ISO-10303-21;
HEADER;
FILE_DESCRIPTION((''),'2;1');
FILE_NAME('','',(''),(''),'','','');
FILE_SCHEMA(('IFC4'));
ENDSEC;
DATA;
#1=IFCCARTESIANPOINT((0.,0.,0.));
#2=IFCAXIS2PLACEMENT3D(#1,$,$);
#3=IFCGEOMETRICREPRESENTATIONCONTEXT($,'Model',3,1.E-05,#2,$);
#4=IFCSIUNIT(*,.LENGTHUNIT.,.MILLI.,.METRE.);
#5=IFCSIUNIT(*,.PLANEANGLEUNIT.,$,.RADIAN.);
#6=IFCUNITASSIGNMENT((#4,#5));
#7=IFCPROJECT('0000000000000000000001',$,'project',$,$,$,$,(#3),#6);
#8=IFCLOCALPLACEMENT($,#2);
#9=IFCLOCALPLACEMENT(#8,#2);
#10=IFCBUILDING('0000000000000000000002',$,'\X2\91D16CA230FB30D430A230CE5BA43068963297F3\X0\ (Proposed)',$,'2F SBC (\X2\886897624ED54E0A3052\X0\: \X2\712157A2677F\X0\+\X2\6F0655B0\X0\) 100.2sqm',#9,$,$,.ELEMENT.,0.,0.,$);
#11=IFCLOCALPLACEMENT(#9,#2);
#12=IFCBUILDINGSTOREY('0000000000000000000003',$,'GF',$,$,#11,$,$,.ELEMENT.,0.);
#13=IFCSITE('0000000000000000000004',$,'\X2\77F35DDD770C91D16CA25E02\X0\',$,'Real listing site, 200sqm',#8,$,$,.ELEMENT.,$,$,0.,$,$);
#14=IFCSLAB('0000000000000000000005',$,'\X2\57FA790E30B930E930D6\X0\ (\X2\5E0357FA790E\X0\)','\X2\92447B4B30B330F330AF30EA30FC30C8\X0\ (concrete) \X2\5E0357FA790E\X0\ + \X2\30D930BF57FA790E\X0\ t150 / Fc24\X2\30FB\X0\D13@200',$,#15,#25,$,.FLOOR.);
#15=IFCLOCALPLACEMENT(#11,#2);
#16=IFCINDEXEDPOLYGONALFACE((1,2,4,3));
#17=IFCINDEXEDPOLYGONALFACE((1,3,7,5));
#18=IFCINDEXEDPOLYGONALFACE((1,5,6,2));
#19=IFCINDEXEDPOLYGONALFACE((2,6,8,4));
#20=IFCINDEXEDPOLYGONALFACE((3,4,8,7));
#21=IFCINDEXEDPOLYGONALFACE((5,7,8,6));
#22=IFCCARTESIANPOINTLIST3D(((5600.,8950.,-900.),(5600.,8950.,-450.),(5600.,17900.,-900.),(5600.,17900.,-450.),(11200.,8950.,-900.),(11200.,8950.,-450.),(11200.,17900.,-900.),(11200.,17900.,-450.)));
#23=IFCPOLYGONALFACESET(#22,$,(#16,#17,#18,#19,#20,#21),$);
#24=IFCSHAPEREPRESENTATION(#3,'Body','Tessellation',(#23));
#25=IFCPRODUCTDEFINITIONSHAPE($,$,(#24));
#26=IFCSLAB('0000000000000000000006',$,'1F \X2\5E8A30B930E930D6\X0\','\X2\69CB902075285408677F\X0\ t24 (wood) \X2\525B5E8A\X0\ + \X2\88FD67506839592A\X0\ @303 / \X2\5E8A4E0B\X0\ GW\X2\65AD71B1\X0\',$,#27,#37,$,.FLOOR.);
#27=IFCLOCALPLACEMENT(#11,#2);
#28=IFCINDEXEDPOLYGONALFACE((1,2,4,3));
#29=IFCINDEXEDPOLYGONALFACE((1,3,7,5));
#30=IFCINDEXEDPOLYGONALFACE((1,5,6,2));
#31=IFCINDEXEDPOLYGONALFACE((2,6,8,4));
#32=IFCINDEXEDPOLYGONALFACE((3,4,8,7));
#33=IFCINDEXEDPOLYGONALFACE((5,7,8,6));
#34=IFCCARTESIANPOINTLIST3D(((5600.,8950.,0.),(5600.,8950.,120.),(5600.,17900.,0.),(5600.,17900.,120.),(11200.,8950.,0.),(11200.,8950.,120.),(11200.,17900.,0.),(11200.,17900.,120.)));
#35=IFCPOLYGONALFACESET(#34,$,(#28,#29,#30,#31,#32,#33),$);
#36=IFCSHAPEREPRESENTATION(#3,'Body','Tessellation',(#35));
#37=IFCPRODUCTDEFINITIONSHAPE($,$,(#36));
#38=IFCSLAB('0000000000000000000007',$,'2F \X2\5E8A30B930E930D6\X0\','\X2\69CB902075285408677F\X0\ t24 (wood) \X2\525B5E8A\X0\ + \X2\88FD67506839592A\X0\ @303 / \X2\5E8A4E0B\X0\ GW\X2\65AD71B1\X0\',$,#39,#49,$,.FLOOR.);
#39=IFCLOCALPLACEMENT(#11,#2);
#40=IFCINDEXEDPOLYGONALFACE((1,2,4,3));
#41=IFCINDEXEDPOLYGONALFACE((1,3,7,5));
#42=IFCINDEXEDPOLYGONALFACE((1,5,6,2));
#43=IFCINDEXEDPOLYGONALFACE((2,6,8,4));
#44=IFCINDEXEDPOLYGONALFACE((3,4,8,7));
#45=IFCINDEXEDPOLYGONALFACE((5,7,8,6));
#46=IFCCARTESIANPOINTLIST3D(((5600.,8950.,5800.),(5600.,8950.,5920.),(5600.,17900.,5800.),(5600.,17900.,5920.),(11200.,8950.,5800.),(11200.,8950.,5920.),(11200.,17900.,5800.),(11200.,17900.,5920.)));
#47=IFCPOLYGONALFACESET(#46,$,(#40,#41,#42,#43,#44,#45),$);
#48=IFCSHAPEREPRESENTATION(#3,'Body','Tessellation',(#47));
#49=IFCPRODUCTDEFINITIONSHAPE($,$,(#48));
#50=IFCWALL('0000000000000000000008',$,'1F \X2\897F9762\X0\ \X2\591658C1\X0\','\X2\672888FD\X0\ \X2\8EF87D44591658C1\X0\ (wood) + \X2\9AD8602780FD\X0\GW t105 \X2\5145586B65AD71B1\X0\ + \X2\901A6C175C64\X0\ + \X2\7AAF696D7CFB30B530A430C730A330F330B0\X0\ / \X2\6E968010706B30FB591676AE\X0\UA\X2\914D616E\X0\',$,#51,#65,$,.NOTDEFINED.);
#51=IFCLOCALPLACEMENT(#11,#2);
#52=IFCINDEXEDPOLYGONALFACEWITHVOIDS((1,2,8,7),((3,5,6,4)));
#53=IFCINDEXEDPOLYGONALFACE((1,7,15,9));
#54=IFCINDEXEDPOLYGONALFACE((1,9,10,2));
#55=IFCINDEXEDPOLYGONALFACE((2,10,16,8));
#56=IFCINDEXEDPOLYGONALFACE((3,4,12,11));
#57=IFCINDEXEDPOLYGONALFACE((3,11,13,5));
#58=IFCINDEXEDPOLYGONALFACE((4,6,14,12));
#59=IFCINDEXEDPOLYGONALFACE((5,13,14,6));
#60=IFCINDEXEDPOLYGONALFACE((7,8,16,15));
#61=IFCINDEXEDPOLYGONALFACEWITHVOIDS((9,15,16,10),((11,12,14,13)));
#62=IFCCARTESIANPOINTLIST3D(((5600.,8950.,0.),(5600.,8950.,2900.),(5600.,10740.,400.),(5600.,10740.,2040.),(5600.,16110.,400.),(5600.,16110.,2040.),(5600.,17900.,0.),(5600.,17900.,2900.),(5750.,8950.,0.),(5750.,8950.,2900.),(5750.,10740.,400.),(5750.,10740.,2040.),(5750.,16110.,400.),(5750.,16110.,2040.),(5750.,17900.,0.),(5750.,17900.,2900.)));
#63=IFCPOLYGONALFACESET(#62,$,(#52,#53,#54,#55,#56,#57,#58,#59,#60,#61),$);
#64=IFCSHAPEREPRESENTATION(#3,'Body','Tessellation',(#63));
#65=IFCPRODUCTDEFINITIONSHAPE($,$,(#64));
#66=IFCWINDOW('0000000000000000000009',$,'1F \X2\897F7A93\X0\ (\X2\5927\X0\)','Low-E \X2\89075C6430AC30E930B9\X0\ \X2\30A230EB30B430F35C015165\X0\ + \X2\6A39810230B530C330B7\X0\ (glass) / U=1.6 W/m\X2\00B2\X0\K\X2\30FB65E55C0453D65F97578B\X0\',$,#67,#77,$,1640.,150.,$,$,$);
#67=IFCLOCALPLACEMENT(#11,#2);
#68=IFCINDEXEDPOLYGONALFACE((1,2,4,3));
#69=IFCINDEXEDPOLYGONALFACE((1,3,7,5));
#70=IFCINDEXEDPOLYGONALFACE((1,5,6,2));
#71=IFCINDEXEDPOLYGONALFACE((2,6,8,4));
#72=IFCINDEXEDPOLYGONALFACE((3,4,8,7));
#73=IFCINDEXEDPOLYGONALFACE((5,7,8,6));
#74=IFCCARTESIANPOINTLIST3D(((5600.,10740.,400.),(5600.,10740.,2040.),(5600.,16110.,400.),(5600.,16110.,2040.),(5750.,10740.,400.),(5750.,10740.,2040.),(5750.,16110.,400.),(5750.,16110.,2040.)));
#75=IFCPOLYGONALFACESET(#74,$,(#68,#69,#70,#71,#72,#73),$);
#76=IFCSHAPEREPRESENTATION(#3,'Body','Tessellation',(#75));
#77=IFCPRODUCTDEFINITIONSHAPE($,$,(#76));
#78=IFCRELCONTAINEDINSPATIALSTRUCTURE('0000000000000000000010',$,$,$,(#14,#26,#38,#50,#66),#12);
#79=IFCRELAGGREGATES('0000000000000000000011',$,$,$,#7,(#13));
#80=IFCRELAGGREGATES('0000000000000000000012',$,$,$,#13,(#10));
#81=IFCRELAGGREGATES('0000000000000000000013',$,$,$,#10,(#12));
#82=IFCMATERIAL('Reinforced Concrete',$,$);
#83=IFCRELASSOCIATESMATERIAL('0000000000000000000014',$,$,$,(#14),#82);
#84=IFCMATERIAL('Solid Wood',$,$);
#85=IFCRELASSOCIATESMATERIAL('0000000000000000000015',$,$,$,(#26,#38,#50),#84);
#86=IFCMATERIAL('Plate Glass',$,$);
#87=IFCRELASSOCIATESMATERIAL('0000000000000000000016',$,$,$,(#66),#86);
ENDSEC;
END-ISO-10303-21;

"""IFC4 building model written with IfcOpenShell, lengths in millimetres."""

from ifc_helpers import new_model, si_unit, frame, frame_2d, origin, place, context, project, spatial, rectangle, extrude, material, element, fill, save


model = new_model("IFC4")

# Units and contexts
model_context = context("Model", 3, precision=1e-05, world=origin())
ifc_project = project(units=[si_unit("LENGTHUNIT", "METRE", prefix="MILLI"), si_unit("PLANEANGLEUNIT", "RADIAN")], contexts=[model_context])

# Site, building, storey
site_placement = place(None, origin())
site = spatial("IfcSite", under=ifc_project, at=site_placement, Name="石川県金沢市", ObjectType="Real listing site, 200sqm", CompositionType="ELEMENT", RefElevation=0.0)
building_placement = place(site_placement, origin())
building = spatial("IfcBuilding", under=site, at=building_placement, Name="金沢・ピアノ室と防音 (Proposed)", ObjectType="2F SBC (表面仕上げ: 無垢板+漆喰) 100.2sqm", CompositionType="ELEMENT", ElevationOfRefHeight=0.0, ElevationOfTerrain=0.0)
storey_placement = place(building_placement, origin())
storey = spatial("IfcBuildingStorey", under=building, at=storey_placement, Name="GF", CompositionType="ELEMENT", Elevation=0.0)

# Shared definitions
ifc_material_1 = material(Name="Solid Wood")

# Slabs
ifc_material_2 = material(Name="Reinforced Concrete")
slab_1_placement = place(storey_placement, frame((2800.0, 4475.0, -450.0)))
element("IfcSlab", 1, at=slab_1_placement, inside=storey, material=ifc_material_2, Name="基礎スラブ (布基礎)", Description="鉄筋コンクリート (concrete) 布基礎 + ベタ基礎 t150 / Fc24・D13@200", PredefinedType="FLOOR", context=model_context, shape_type="SweptSolid", body=[
    extrude(rectangle(XDim=5600.0, YDim=8950.0, at=frame_2d((2800.0, 4475.0))), frame((2800.0, 4475.0, -450.0)), (0.0, 0.0, 1.0), 450.0),
])
slab_2_placement = place(storey_placement, frame((2800.0, 4475.0, 0.0)))
element("IfcSlab", 2, at=slab_2_placement, inside=storey, material=ifc_material_1, Name="1F 床スラブ", Description="構造用合板 t24 (wood) 剛床 + 製材根太 @303 / 床下 GW断熱", PredefinedType="FLOOR", context=model_context, shape_type="SweptSolid", body=[
    extrude(rectangle(XDim=5600.0, YDim=8950.0, at=frame_2d((2800.0, 4475.0))), frame((2800.0, 4475.0, 0.0)), (0.0, 0.0, 1.0), 120.0),
])
slab_3_placement = place(storey_placement, frame((2800.0, 4475.0, 2900.0)))
element("IfcSlab", 3, at=slab_3_placement, inside=storey, material=ifc_material_1, Name="2F 床スラブ", Description="構造用合板 t24 (wood) 剛床 + 製材根太 @303 / 床下 GW断熱", PredefinedType="FLOOR", context=model_context, shape_type="SweptSolid", body=[
    extrude(rectangle(XDim=5600.0, YDim=8950.0, at=frame_2d((2800.0, 4475.0))), frame((2800.0, 4475.0, 2900.0)), (0.0, 0.0, 1.0), 120.0),
])

# Shared definitions
ifc_material_3 = material(Name="Plate Glass")

# Wall, opening, window
wall_1_placement = place(storey_placement, frame((2800.0, 4475.0, 0.0)))
wall_1 = element("IfcWall", 4, at=wall_1_placement, inside=storey, material=ifc_material_1, Name="1F 西面 外壁", Description="木製 軸組外壁 (wood) + 高性能GW t105 充填断熱 + 通気層 + 窯業系サイディング / 準耐火・外皮UA配慮", PredefinedType="NOTDEFINED", context=model_context, shape_type="SweptSolid", body=[
    extrude(rectangle(XDim=150.0, YDim=8950.0, at=frame_2d((75.0, 4475.0))), frame((2800.0, 4475.0, 0.0)), (0.0, 0.0, 1.0), 2900.0),
])
opening_1_placement = place(storey_placement, frame((2800.0, 5370.0, 200.0)))
opening_1 = element("IfcOpeningElement", 5, at=opening_1_placement, cuts=wall_1, PredefinedType="NOTDEFINED", context=model_context, shape_type="SweptSolid", body=[
    extrude(rectangle(XDim=150.0, YDim=5370.0, at=frame_2d((75.0, 2685.0))), frame((2800.0, 5370.0, 200.0)), (0.0, 0.0, 1.0), 1640.0),
])
window_1_placement = place(storey_placement, frame((2800.0, 5370.0, 200.0)))
window_1 = element("IfcWindow", 6, at=window_1_placement, inside=storey, material=ifc_material_3, Name="1F 西窓 (大)", Description="Low-E 複層ガラス アルゴン封入 + 樹脂サッシ (glass) / U=1.6 W/m²K・日射取得型", OverallHeight=1640.0, OverallWidth=150.0, context=model_context, shape_type="SweptSolid", body=[
    extrude(rectangle(XDim=150.0, YDim=5370.0, at=frame_2d((75.0, 2685.0))), frame((2800.0, 5370.0, 200.0)), (0.0, 0.0, 1.0), 1640.0),
])
fill(opening_1, window_1)

save(model, "model.ifc")
